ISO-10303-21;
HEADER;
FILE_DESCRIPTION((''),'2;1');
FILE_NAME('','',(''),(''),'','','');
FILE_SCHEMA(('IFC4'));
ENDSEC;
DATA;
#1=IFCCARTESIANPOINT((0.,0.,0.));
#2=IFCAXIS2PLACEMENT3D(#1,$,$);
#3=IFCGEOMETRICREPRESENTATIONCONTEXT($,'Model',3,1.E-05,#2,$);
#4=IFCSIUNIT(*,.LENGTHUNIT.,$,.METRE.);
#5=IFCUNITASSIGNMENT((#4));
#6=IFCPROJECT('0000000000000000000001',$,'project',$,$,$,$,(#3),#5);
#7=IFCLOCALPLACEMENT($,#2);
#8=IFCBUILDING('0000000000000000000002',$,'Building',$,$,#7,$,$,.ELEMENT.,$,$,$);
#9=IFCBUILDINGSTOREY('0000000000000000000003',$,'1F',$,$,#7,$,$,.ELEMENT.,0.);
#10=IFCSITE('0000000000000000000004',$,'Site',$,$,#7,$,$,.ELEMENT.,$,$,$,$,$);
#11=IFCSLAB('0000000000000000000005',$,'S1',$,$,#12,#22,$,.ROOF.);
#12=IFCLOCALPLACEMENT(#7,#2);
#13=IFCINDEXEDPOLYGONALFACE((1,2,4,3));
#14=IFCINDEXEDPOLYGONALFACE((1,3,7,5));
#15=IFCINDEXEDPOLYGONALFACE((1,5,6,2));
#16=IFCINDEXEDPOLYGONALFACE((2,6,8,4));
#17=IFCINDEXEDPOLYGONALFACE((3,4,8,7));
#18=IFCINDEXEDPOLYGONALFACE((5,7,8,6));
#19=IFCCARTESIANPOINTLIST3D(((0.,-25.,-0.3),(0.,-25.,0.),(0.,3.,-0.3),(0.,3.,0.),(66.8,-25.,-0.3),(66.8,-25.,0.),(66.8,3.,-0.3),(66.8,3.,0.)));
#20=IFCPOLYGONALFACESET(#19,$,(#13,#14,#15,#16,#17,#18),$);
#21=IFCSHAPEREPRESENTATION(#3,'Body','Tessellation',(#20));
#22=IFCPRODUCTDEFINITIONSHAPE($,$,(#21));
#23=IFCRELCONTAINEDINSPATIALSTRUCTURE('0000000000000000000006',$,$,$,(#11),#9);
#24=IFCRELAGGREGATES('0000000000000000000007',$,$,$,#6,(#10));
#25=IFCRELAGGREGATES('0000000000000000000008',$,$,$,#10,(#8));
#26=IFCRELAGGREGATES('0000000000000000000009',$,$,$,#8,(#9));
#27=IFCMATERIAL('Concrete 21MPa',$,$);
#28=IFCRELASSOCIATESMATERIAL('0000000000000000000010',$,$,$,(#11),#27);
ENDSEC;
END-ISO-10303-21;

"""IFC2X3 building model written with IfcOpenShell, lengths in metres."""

from ifc_helpers import new_model, si_unit, frame, origin, origin_2d, place, context, project, spatial, rectangle, extrude, material, element, save


model = new_model("IFC2X3")

# Units and contexts
model_context = context("Model", 3, precision=1e-05, world=origin())
ifc_project = project(units=[si_unit("LENGTHUNIT", "METRE")], contexts=[model_context])

# Site, building, storey
placement = place(None, origin())
site = spatial("IfcSite", under=ifc_project, at=placement, Name="Site", CompositionType="ELEMENT")
building = spatial("IfcBuilding", under=site, at=placement, Name="Building", CompositionType="ELEMENT")
storey = spatial("IfcBuildingStorey", under=building, at=placement, Name="1F", CompositionType="ELEMENT", Elevation=0.0)

# Slab
ifc_material = material(Name="Concrete 21MPa")
slab_placement = place(None, frame((33.4, -11.0, -0.3)))
element("IfcSlab", 1, at=slab_placement, inside=storey, material=ifc_material, Name="S1", PredefinedType="ROOF", context=model_context, shape_type="SweptSolid", body=[
    extrude(rectangle(XDim=66.8, YDim=28.0, at=origin_2d()), origin(), (0.0, 0.0, 1.0), 0.3),
])

save(model, "model.ifc")
